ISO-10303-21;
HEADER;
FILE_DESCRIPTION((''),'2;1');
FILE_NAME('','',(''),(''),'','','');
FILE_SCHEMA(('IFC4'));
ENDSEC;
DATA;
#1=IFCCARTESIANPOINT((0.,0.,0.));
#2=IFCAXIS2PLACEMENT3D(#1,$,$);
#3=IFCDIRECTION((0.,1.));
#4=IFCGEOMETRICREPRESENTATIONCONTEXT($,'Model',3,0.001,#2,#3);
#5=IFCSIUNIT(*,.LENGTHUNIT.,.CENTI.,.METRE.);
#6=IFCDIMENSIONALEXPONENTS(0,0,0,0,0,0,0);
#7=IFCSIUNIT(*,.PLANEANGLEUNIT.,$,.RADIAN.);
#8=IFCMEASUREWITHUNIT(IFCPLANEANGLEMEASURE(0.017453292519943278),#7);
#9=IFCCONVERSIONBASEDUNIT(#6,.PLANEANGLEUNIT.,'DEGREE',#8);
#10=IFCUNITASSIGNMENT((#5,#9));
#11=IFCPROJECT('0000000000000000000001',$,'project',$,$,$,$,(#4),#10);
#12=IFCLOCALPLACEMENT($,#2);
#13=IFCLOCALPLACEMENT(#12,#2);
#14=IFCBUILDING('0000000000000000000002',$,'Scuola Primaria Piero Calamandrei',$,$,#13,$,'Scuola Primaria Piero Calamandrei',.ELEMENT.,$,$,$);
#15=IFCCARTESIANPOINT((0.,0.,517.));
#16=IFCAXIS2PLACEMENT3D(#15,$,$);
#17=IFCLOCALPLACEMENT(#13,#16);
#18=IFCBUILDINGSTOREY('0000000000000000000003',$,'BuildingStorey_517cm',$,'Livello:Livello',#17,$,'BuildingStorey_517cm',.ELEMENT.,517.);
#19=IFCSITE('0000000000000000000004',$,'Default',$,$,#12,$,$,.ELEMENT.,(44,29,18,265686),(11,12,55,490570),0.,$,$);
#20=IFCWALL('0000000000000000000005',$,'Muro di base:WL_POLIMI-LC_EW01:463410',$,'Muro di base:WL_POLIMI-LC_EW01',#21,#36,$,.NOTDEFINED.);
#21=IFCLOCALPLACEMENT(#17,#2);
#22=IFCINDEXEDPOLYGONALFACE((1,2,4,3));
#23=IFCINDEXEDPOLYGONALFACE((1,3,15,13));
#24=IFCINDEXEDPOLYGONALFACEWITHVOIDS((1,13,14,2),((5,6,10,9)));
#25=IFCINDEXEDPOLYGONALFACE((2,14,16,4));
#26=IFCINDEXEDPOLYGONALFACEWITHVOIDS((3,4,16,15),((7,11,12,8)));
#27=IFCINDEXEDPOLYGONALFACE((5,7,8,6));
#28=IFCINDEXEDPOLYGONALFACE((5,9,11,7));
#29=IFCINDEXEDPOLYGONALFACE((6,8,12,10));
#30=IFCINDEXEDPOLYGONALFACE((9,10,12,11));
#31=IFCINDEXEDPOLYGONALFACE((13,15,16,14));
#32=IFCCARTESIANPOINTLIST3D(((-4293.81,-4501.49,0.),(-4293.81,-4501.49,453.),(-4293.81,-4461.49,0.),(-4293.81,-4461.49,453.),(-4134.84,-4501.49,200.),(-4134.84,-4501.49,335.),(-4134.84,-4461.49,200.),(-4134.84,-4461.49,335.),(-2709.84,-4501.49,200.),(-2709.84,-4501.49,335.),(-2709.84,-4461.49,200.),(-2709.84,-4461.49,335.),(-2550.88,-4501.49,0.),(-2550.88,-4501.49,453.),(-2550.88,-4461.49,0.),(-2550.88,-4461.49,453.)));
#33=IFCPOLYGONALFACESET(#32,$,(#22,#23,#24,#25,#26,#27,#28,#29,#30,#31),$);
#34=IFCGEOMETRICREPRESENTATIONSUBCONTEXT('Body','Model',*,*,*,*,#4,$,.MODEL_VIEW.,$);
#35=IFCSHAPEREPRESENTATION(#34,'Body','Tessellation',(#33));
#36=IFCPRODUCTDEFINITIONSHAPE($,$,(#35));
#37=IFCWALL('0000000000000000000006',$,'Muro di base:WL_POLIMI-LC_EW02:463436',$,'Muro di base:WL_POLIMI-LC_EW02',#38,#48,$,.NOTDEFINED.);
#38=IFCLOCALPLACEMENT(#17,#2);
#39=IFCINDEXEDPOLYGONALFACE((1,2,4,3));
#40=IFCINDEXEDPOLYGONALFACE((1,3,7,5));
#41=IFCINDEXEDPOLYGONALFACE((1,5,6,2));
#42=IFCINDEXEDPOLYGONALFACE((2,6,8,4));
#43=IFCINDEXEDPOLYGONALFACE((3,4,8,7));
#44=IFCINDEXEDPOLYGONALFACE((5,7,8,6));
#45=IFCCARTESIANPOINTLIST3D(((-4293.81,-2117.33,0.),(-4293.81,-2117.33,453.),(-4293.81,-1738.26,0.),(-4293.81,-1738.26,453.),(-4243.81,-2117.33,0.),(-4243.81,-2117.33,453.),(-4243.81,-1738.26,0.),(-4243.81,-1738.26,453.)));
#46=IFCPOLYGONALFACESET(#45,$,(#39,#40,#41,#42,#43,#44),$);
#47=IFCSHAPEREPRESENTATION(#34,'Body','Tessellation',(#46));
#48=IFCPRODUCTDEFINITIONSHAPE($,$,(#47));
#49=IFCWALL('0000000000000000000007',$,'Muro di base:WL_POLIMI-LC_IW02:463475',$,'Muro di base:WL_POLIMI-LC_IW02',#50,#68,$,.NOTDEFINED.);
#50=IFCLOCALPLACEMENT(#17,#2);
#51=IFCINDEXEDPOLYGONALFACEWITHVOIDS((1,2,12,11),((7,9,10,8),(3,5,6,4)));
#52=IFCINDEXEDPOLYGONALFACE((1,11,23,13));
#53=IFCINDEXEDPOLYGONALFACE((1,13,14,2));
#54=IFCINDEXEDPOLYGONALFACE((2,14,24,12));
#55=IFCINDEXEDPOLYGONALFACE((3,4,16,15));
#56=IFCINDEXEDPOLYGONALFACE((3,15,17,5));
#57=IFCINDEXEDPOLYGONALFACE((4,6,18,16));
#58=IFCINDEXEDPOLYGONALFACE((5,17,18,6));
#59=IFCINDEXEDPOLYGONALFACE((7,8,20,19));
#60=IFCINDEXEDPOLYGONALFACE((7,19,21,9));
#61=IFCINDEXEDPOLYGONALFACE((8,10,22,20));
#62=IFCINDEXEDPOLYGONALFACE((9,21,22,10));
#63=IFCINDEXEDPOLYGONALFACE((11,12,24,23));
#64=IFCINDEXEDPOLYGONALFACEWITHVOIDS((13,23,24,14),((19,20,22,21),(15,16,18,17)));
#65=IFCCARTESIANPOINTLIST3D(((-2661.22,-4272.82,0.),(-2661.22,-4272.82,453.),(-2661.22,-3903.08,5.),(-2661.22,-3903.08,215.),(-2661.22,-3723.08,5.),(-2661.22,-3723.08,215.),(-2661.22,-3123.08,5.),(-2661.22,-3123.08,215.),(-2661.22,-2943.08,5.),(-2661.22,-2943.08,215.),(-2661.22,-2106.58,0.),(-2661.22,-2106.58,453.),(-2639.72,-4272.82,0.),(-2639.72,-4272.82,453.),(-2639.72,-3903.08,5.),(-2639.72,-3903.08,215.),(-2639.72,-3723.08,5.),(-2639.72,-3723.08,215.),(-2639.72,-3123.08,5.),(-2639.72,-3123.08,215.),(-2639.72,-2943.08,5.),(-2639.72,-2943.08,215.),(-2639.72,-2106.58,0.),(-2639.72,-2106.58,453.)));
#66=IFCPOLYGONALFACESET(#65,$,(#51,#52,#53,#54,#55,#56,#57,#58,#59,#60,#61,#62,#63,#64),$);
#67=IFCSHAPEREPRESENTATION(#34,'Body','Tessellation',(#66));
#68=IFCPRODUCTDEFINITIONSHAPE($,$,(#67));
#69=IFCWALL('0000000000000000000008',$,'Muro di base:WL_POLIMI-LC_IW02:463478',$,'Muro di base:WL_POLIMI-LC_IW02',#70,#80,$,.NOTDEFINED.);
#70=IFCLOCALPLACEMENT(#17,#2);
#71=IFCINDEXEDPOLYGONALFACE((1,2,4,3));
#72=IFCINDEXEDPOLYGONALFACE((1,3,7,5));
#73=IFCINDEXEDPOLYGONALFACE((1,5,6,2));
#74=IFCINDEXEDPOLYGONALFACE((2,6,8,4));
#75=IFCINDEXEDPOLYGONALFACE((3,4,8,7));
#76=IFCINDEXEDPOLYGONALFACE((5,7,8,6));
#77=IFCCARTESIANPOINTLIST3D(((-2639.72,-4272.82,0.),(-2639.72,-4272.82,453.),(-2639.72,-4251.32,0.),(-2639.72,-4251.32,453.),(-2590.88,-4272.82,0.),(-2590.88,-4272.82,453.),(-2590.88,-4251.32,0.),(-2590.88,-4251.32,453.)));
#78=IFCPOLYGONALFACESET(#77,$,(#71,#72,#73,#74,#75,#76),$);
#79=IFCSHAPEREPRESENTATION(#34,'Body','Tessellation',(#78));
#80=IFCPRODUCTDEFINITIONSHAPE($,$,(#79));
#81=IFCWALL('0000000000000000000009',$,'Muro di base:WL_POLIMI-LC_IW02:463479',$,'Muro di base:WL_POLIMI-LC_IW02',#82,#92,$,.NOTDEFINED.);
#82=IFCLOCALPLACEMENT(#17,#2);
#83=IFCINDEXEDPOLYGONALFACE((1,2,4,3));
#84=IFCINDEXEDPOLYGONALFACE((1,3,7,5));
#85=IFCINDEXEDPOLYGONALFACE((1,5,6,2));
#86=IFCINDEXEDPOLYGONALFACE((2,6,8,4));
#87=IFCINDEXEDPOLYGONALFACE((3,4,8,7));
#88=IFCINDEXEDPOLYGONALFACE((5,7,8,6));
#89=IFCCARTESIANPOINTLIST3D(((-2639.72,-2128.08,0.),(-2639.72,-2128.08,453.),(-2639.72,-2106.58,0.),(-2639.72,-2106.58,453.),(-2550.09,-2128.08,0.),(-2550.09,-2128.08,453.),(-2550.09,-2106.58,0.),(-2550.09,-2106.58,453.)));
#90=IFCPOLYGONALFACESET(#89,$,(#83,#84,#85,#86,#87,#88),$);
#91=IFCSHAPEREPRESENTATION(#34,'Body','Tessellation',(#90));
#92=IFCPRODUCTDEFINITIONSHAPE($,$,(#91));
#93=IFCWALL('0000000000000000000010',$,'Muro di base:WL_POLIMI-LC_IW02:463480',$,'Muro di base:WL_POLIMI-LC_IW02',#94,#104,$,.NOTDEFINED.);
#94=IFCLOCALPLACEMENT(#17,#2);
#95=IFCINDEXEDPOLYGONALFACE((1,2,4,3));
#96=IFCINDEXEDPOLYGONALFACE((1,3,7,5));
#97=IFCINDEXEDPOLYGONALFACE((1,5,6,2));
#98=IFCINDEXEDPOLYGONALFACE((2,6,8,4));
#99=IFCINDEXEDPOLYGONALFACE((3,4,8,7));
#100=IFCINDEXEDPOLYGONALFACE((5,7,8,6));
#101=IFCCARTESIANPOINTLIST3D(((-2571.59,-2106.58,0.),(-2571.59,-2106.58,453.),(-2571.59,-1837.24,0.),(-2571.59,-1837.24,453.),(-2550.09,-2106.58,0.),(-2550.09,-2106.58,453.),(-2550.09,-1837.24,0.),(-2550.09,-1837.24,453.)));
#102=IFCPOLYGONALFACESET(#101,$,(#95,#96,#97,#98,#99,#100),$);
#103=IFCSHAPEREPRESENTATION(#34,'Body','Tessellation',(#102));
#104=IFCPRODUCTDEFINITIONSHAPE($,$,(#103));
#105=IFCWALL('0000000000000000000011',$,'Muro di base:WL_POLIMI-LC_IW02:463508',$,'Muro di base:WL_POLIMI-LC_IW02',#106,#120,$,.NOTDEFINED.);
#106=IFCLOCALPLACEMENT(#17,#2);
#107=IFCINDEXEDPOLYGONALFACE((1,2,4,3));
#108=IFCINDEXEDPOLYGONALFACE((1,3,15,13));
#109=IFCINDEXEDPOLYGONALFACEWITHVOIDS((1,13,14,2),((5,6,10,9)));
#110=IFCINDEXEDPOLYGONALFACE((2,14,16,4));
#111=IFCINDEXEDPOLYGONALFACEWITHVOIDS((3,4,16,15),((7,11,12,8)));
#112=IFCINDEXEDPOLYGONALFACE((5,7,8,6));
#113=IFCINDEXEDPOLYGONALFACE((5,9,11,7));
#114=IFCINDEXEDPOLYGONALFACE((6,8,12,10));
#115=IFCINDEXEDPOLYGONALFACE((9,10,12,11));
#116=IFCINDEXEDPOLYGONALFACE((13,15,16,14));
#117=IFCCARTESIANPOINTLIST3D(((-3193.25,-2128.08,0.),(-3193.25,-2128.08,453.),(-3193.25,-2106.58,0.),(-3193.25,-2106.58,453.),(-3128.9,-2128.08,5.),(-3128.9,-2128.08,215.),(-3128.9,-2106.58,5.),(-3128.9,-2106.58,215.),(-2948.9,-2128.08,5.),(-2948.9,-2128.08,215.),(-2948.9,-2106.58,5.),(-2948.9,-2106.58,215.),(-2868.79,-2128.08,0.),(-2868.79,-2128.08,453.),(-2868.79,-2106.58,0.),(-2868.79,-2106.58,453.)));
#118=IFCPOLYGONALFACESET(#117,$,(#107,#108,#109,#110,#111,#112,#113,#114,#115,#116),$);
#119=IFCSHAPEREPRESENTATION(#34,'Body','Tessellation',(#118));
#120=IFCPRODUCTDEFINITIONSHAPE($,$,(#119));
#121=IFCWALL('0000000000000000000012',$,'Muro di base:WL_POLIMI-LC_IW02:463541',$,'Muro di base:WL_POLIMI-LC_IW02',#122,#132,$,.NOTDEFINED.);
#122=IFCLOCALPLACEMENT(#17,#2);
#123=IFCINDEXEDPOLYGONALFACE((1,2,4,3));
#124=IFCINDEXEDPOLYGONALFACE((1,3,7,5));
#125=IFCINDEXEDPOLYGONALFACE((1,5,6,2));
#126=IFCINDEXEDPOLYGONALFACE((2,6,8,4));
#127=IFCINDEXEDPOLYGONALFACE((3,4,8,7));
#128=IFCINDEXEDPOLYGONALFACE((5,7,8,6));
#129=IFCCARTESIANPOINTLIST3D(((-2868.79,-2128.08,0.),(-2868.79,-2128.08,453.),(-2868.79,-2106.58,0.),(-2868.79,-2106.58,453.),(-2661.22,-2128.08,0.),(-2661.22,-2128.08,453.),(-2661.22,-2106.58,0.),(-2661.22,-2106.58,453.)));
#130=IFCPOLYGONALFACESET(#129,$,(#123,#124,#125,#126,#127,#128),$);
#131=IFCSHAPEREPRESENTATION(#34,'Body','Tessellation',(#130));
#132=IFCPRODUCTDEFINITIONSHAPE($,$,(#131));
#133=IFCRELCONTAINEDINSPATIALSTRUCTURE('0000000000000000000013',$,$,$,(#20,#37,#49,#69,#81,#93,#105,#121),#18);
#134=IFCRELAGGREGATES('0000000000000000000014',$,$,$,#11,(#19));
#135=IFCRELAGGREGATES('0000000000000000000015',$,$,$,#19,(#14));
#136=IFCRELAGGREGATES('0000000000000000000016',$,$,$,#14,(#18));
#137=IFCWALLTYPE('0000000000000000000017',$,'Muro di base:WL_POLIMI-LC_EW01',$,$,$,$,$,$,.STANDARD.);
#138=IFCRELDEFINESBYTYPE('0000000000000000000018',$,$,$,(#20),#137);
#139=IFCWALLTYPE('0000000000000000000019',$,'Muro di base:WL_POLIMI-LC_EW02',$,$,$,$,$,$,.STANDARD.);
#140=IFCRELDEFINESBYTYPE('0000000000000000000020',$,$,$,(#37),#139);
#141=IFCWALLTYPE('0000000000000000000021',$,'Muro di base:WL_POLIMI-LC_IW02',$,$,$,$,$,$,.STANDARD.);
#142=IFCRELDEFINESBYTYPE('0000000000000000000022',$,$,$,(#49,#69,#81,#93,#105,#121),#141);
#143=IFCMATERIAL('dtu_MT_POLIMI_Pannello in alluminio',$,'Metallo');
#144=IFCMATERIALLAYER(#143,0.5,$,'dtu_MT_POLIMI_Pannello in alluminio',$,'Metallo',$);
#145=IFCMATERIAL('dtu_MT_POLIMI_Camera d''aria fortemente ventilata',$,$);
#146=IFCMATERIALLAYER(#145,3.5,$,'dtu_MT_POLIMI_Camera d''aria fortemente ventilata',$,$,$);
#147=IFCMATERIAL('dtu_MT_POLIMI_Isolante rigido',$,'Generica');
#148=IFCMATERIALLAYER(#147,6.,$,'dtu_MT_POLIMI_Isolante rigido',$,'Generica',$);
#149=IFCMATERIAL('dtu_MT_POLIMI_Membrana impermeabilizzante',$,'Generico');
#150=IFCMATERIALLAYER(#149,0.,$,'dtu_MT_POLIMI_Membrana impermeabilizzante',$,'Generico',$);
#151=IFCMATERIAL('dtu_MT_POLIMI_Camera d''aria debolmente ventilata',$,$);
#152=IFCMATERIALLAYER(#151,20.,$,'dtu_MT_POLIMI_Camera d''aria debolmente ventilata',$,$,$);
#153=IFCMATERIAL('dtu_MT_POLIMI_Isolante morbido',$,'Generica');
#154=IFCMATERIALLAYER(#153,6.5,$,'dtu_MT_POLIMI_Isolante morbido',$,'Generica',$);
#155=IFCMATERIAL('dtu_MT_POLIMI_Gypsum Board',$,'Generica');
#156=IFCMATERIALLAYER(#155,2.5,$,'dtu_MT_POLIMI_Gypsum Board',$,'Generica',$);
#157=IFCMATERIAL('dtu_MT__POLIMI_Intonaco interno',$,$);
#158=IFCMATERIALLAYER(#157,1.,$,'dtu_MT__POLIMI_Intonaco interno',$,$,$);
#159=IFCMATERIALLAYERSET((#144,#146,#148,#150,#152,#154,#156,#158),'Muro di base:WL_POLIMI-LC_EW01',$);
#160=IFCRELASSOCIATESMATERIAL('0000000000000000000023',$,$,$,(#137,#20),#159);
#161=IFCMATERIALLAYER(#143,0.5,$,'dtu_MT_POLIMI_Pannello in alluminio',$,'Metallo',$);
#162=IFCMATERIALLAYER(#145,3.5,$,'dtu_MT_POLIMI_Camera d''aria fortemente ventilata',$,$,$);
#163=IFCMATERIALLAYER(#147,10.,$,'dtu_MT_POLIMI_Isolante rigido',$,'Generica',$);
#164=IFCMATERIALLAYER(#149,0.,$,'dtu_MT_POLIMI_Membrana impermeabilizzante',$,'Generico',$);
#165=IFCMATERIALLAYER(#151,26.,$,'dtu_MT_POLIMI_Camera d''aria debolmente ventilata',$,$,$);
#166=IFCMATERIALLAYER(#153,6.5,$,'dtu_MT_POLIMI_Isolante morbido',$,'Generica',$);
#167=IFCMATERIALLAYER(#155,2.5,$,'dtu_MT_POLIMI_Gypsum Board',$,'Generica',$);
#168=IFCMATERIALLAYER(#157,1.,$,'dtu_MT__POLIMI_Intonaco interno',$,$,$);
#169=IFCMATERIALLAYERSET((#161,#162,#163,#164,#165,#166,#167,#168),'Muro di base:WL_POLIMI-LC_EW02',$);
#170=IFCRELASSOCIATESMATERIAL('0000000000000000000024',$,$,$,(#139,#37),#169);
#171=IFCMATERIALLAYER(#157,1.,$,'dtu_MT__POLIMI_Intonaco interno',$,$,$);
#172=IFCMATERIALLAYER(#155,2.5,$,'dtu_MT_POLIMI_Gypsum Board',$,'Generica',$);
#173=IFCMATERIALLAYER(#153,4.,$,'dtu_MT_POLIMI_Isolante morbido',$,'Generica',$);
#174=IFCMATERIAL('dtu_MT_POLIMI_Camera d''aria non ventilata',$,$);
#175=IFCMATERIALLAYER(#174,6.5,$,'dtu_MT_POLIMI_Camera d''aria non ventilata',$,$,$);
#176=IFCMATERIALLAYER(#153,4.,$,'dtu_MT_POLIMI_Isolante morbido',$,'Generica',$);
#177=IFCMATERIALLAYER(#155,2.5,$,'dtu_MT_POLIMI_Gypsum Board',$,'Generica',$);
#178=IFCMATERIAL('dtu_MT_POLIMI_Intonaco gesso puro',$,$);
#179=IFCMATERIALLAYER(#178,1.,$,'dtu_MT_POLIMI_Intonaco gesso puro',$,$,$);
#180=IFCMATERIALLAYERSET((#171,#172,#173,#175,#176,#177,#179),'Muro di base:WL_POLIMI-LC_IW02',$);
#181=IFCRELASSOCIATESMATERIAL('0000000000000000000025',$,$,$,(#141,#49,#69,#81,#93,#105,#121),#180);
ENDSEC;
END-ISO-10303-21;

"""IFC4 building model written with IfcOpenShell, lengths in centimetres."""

from ifc_helpers import new_model, entity, si_unit, converted_unit, direction, frame, frame_2d, origin, place, context, subcontext, project, spatial, polyline, rectangle, extrude, clip, bounded_halfspace, material, layer, layer_set, layer_usage, type_object, element, save


model = new_model("IFC4")

# Units and contexts
model_context = context("Model", 3, precision=0.001, world=origin(), true_north=direction((0.0, 1.0)))
body_context = subcontext(model_context, "Body", "Model", "MODEL_VIEW")
ifc_project = project(units=[si_unit("LENGTHUNIT", "METRE", prefix="CENTI"), converted_unit("PLANEANGLEUNIT", "DEGREE", entity("IfcPlaneAngleMeasure", 0.017453292519943278), si_unit("PLANEANGLEUNIT", "RADIAN"), dimensions=[0, 0, 0, 0, 0, 0, 0])], contexts=[model_context])

# Site, building, storey
site_placement = place(None, origin())
site = spatial("IfcSite", under=ifc_project, at=site_placement, Name="Default", CompositionType="ELEMENT", RefLatitude=(44, 29, 18, 265686), RefLongitude=(11, 12, 55, 490570), RefElevation=0.0)
building_placement = place(site_placement, origin())
building = spatial("IfcBuilding", under=site, at=building_placement, Name="Scuola Primaria Piero Calamandrei", LongName="Scuola Primaria Piero Calamandrei", CompositionType="ELEMENT")
storey_placement = place(building_placement, frame((0.0, 0.0, 517.0)))
storey = spatial("IfcBuildingStorey", under=building, at=storey_placement, Name="BuildingStorey_517cm", ObjectType="Livello:Livello", LongName="BuildingStorey_517cm", CompositionType="ELEMENT", Elevation=517.0)

# Wall, opening
ifc_material_1 = material(Name="dtu_MT_POLIMI_Pannello in alluminio", Category="Metallo")
ifc_layer_1 = layer(ifc_material_1, 0.5, Name="dtu_MT_POLIMI_Pannello in alluminio", Category="Metallo")
ifc_material_2 = material(Name="dtu_MT_POLIMI_Camera d'aria fortemente ventilata")
ifc_layer_2 = layer(ifc_material_2, 3.5, Name="dtu_MT_POLIMI_Camera d'aria fortemente ventilata")
ifc_material_3 = material(Name="dtu_MT_POLIMI_Isolante rigido", Category="Generica")
ifc_layer_3 = layer(ifc_material_3, 6.0, Name="dtu_MT_POLIMI_Isolante rigido", Category="Generica")
ifc_material_4 = material(Name="dtu_MT_POLIMI_Membrana impermeabilizzante", Category="Generico")
ifc_layer_4 = layer(ifc_material_4, 0.0, Name="dtu_MT_POLIMI_Membrana impermeabilizzante", Category="Generico")
ifc_material_5 = material(Name="dtu_MT_POLIMI_Camera d'aria debolmente ventilata")
ifc_layer_5 = layer(ifc_material_5, 20.0, Name="dtu_MT_POLIMI_Camera d'aria debolmente ventilata")
ifc_material_6 = material(Name="dtu_MT_POLIMI_Isolante morbido", Category="Generica")
ifc_layer_6 = layer(ifc_material_6, 6.5, Name="dtu_MT_POLIMI_Isolante morbido", Category="Generica")
ifc_material_7 = material(Name="dtu_MT_POLIMI_Gypsum Board", Category="Generica")
ifc_layer_7 = layer(ifc_material_7, 2.5, Name="dtu_MT_POLIMI_Gypsum Board", Category="Generica")
ifc_material_8 = material(Name="dtu_MT__POLIMI_Intonaco interno")
ifc_layer_8 = layer(ifc_material_8, 1.0, Name="dtu_MT__POLIMI_Intonaco interno")
ifc_layer_set_1 = layer_set([ifc_layer_1, ifc_layer_2, ifc_layer_3, ifc_layer_4, ifc_layer_5, ifc_layer_6, ifc_layer_7, ifc_layer_8], Name="Muro di base:WL_POLIMI-LC_EW01")
ifc_layer_usage_1 = layer_usage(ifc_layer_set_1, "AXIS2", "NEGATIVE", 20.0)
wall_type_1 = type_object("IfcWallType", Name="Muro di base:WL_POLIMI-LC_EW01", PredefinedType="STANDARD", material=ifc_layer_set_1)
wall_1_placement = place(storey_placement, frame((-2550.88, -4481.49, 0.0), z_axis=(0.0, 0.0, 1.0), x_axis=(-1.0, 0.0, 0.0)))
wall_1 = element("IfcWall", 1, at=wall_1_placement, inside=storey, type_object=wall_type_1, material=ifc_layer_usage_1, Name="Muro di base:WL_POLIMI-LC_EW01:463410", ObjectType="Muro di base:WL_POLIMI-LC_EW01", PredefinedType="NOTDEFINED", context=body_context, shape_type="Clipping", body=[
    clip(extrude(rectangle(XDim=1742.93, YDim=40.0, at=frame_2d((871.47, 0.0), x_axis=(-1.0, 0.0))), origin(), (0.0, 0.0, 1.0), 453.0), bounded_halfspace(frame((0.0, -20.0, 453.0), z_axis=(0.0, 0.0, 1.0), x_axis=(-1.0, 0.0, 0.0)), False, frame((0.0, -20.0, 453.0)), polyline([(0.0, 0.0), (40.0, 0.0), (1737.93, 0.0), (1742.93, 0.0), (1742.93, 40.0), (0.0, 40.0), (0.0, 0.0)]))),
])
opening_1_placement = place(wall_1_placement, frame((158.97, -20.0, 200.0)))
element("IfcOpeningElement", 2, at=opening_1_placement, cuts=wall_1, PredefinedType="OPENING", context=body_context, shape_type="SweptSolid", body=[
    extrude(rectangle(XDim=135.0, YDim=1425.0, at=frame_2d((67.5, 712.5), x_axis=(-1.0, 0.0))), frame((0.0, 0.0, 0.0), z_axis=(0.0, 1.0, 0.0), x_axis=(0.0, 0.0, 1.0)), (0.0, 0.0, 1.0), 40.0),
])

# Wall
ifc_layer_9 = layer(ifc_material_1, 0.5, Name="dtu_MT_POLIMI_Pannello in alluminio", Category="Metallo")
ifc_layer_10 = layer(ifc_material_2, 3.5, Name="dtu_MT_POLIMI_Camera d'aria fortemente ventilata")
ifc_layer_11 = layer(ifc_material_3, 10.0, Name="dtu_MT_POLIMI_Isolante rigido", Category="Generica")
ifc_layer_12 = layer(ifc_material_4, 0.0, Name="dtu_MT_POLIMI_Membrana impermeabilizzante", Category="Generico")
ifc_layer_13 = layer(ifc_material_5, 26.0, Name="dtu_MT_POLIMI_Camera d'aria debolmente ventilata")
ifc_layer_14 = layer(ifc_material_6, 6.5, Name="dtu_MT_POLIMI_Isolante morbido", Category="Generica")
ifc_layer_15 = layer(ifc_material_7, 2.5, Name="dtu_MT_POLIMI_Gypsum Board", Category="Generica")
ifc_layer_16 = layer(ifc_material_8, 1.0, Name="dtu_MT__POLIMI_Intonaco interno")
ifc_layer_set_2 = layer_set([ifc_layer_9, ifc_layer_10, ifc_layer_11, ifc_layer_12, ifc_layer_13, ifc_layer_14, ifc_layer_15, ifc_layer_16], Name="Muro di base:WL_POLIMI-LC_EW02")
ifc_layer_usage_2 = layer_usage(ifc_layer_set_2, "AXIS2", "NEGATIVE", 25.0)
wall_type_2 = type_object("IfcWallType", Name="Muro di base:WL_POLIMI-LC_EW02", PredefinedType="STANDARD", material=ifc_layer_set_2)
wall_2_placement = place(storey_placement, frame((-4268.81, -2117.33, 0.0), z_axis=(0.0, 0.0, 1.0), x_axis=(0.0, 1.0, 0.0)))
element("IfcWall", 3, at=wall_2_placement, inside=storey, type_object=wall_type_2, material=ifc_layer_usage_2, Name="Muro di base:WL_POLIMI-LC_EW02:463436", ObjectType="Muro di base:WL_POLIMI-LC_EW02", PredefinedType="NOTDEFINED", context=body_context, shape_type="Clipping", body=[
    clip(extrude(rectangle(XDim=379.07, YDim=50.0, at=frame_2d((189.54, 0.0), x_axis=(-1.0, 0.0))), origin(), (0.0, 0.0, 1.0), 453.0), bounded_halfspace(frame((0.0, -25.0, 453.0), z_axis=(0.0, 0.0, 1.0), x_axis=(0.0, -1.0, 0.0)), False, frame((0.0, -25.0, 453.0)), polyline([(0.0, 0.0), (11.5, 0.0), (366.82, 0.0), (379.07, 0.0), (379.07, 50.0), (0.0, 50.0), (0.0, 45.0), (0.0, 0.0)]))),
])

# Wall, openings
ifc_layer_17 = layer(ifc_material_8, 1.0, Name="dtu_MT__POLIMI_Intonaco interno")
ifc_layer_18 = layer(ifc_material_7, 2.5, Name="dtu_MT_POLIMI_Gypsum Board", Category="Generica")
ifc_layer_19 = layer(ifc_material_6, 4.0, Name="dtu_MT_POLIMI_Isolante morbido", Category="Generica")
ifc_material_9 = material(Name="dtu_MT_POLIMI_Camera d'aria non ventilata")
ifc_layer_20 = layer(ifc_material_9, 6.5, Name="dtu_MT_POLIMI_Camera d'aria non ventilata")
ifc_layer_21 = layer(ifc_material_6, 4.0, Name="dtu_MT_POLIMI_Isolante morbido", Category="Generica")
ifc_layer_22 = layer(ifc_material_7, 2.5, Name="dtu_MT_POLIMI_Gypsum Board", Category="Generica")
ifc_material_10 = material(Name="dtu_MT_POLIMI_Intonaco gesso puro")
ifc_layer_23 = layer(ifc_material_10, 1.0, Name="dtu_MT_POLIMI_Intonaco gesso puro")
ifc_layer_set_3 = layer_set([ifc_layer_17, ifc_layer_18, ifc_layer_19, ifc_layer_20, ifc_layer_21, ifc_layer_22, ifc_layer_23], Name="Muro di base:WL_POLIMI-LC_IW02")
ifc_layer_usage_3 = layer_usage(ifc_layer_set_3, "AXIS2", "NEGATIVE", 10.75)
wall_type_3 = type_object("IfcWallType", Name="Muro di base:WL_POLIMI-LC_IW02", PredefinedType="STANDARD", material=ifc_layer_set_3)
wall_3_placement = place(storey_placement, frame((-2650.47, -4272.82, 0.0), z_axis=(0.0, 0.0, 1.0), x_axis=(0.0, 1.0, 0.0)))
wall_3 = element("IfcWall", 4, at=wall_3_placement, inside=storey, type_object=wall_type_3, material=ifc_layer_usage_3, Name="Muro di base:WL_POLIMI-LC_IW02:463475", ObjectType="Muro di base:WL_POLIMI-LC_IW02", PredefinedType="NOTDEFINED", context=body_context, shape_type="SweptSolid", body=[
    extrude(rectangle(XDim=2166.24, YDim=21.5, at=frame_2d((1083.12, 0.0), x_axis=(-1.0, 0.0))), origin(), (0.0, 0.0, 1.0), 453.0),
])
opening_2_placement = place(wall_3_placement, frame((1329.74, 10.75, 5.0)))
element("IfcOpeningElement", 5, at=opening_2_placement, cuts=wall_3, PredefinedType="OPENING", context=body_context, shape_type="SweptSolid", body=[
    extrude(rectangle(XDim=210.0, YDim=180.0, at=frame_2d((105.0, 90.0), x_axis=(-1.0, 0.0))), frame((0.0, 0.0, 0.0), z_axis=(0.0, -1.0, 0.0), x_axis=(0.0, 0.0, 1.0)), (0.0, 0.0, 1.0), 21.5),
])
opening_3_placement = place(wall_3_placement, frame((549.74, 10.75, 5.0)))
element("IfcOpeningElement", 6, at=opening_3_placement, cuts=wall_3, PredefinedType="OPENING", context=body_context, shape_type="SweptSolid", body=[
    extrude(rectangle(XDim=210.0, YDim=180.0, at=frame_2d((105.0, 90.0), x_axis=(-1.0, 0.0))), frame((0.0, 0.0, 0.0), z_axis=(0.0, -1.0, 0.0), x_axis=(0.0, 0.0, 1.0)), (0.0, 0.0, 1.0), 21.5),
])

# Walls
ifc_layer_usage_4 = layer_usage(ifc_layer_set_3, "AXIS2", "NEGATIVE", 10.75)
wall_4_placement = place(storey_placement, frame((-2590.88, -4262.07, 0.0), z_axis=(0.0, 0.0, 1.0), x_axis=(-1.0, 0.0, 0.0)))
element("IfcWall", 7, at=wall_4_placement, inside=storey, type_object=wall_type_3, material=ifc_layer_usage_4, Name="Muro di base:WL_POLIMI-LC_IW02:463478", ObjectType="Muro di base:WL_POLIMI-LC_IW02", PredefinedType="NOTDEFINED", context=body_context, shape_type="SweptSolid", body=[
    extrude(rectangle(XDim=48.85, YDim=21.5, at=frame_2d((24.42, 0.0), x_axis=(-1.0, 0.0))), origin(), (0.0, 0.0, 1.0), 453.0),
])
ifc_layer_usage_5 = layer_usage(ifc_layer_set_3, "AXIS2", "NEGATIVE", 10.75)
wall_5_placement = place(storey_placement, frame((-2639.72, -2117.33, 0.0)))
element("IfcWall", 8, at=wall_5_placement, inside=storey, type_object=wall_type_3, material=ifc_layer_usage_5, Name="Muro di base:WL_POLIMI-LC_IW02:463479", ObjectType="Muro di base:WL_POLIMI-LC_IW02", PredefinedType="NOTDEFINED", context=body_context, shape_type="SweptSolid", body=[
    extrude(rectangle(XDim=89.64, YDim=21.5, at=frame_2d((44.82, 0.0), x_axis=(-1.0, 0.0))), origin(), (0.0, 0.0, 1.0), 453.0),
])
ifc_layer_usage_6 = layer_usage(ifc_layer_set_3, "AXIS2", "NEGATIVE", 10.75)
wall_6_placement = place(storey_placement, frame((-2560.84, -2106.58, 0.0), z_axis=(0.0, 0.0, 1.0), x_axis=(0.0, 1.0, 0.0)))
element("IfcWall", 9, at=wall_6_placement, inside=storey, type_object=wall_type_3, material=ifc_layer_usage_6, Name="Muro di base:WL_POLIMI-LC_IW02:463480", ObjectType="Muro di base:WL_POLIMI-LC_IW02", PredefinedType="NOTDEFINED", context=body_context, shape_type="SweptSolid", body=[
    extrude(rectangle(XDim=269.34, YDim=21.5, at=frame_2d((134.67, 0.0), x_axis=(-1.0, 0.0))), origin(), (0.0, 0.0, 1.0), 453.0),
])

# Wall, opening
ifc_layer_usage_7 = layer_usage(ifc_layer_set_3, "AXIS2", "NEGATIVE", 10.75)
wall_7_placement = place(storey_placement, frame((-2868.79, -2117.33, 0.0), z_axis=(0.0, 0.0, 1.0), x_axis=(-1.0, 0.0, 0.0)))
wall_7 = element("IfcWall", 10, at=wall_7_placement, inside=storey, type_object=wall_type_3, material=ifc_layer_usage_7, Name="Muro di base:WL_POLIMI-LC_IW02:463508", ObjectType="Muro di base:WL_POLIMI-LC_IW02", PredefinedType="NOTDEFINED", context=body_context, shape_type="SweptSolid", body=[
    extrude(rectangle(XDim=324.46, YDim=21.5, at=frame_2d((162.23, 0.0), x_axis=(-1.0, 0.0))), origin(), (0.0, 0.0, 1.0), 453.0),
])
opening_4_placement = place(wall_7_placement, frame((260.1, 10.75, 5.0)))
element("IfcOpeningElement", 11, at=opening_4_placement, cuts=wall_7, PredefinedType="OPENING", context=body_context, shape_type="SweptSolid", body=[
    extrude(rectangle(XDim=210.0, YDim=180.0, at=frame_2d((105.0, 90.0), x_axis=(-1.0, 0.0))), frame((0.0, 0.0, 0.0), z_axis=(0.0, -1.0, 0.0), x_axis=(0.0, 0.0, 1.0)), (0.0, 0.0, 1.0), 21.5),
])

# Wall
ifc_layer_usage_8 = layer_usage(ifc_layer_set_3, "AXIS2", "NEGATIVE", 10.75)
wall_8_placement = place(storey_placement, frame((-2868.79, -2117.33, 0.0)))
element("IfcWall", 12, at=wall_8_placement, inside=storey, type_object=wall_type_3, material=ifc_layer_usage_8, Name="Muro di base:WL_POLIMI-LC_IW02:463541", ObjectType="Muro di base:WL_POLIMI-LC_IW02", PredefinedType="NOTDEFINED", context=body_context, shape_type="SweptSolid", body=[
    extrude(rectangle(XDim=207.57, YDim=21.5, at=frame_2d((103.79, 0.0), x_axis=(-1.0, 0.0))), origin(), (0.0, 0.0, 1.0), 453.0),
])

save(model, "model.ifc")
